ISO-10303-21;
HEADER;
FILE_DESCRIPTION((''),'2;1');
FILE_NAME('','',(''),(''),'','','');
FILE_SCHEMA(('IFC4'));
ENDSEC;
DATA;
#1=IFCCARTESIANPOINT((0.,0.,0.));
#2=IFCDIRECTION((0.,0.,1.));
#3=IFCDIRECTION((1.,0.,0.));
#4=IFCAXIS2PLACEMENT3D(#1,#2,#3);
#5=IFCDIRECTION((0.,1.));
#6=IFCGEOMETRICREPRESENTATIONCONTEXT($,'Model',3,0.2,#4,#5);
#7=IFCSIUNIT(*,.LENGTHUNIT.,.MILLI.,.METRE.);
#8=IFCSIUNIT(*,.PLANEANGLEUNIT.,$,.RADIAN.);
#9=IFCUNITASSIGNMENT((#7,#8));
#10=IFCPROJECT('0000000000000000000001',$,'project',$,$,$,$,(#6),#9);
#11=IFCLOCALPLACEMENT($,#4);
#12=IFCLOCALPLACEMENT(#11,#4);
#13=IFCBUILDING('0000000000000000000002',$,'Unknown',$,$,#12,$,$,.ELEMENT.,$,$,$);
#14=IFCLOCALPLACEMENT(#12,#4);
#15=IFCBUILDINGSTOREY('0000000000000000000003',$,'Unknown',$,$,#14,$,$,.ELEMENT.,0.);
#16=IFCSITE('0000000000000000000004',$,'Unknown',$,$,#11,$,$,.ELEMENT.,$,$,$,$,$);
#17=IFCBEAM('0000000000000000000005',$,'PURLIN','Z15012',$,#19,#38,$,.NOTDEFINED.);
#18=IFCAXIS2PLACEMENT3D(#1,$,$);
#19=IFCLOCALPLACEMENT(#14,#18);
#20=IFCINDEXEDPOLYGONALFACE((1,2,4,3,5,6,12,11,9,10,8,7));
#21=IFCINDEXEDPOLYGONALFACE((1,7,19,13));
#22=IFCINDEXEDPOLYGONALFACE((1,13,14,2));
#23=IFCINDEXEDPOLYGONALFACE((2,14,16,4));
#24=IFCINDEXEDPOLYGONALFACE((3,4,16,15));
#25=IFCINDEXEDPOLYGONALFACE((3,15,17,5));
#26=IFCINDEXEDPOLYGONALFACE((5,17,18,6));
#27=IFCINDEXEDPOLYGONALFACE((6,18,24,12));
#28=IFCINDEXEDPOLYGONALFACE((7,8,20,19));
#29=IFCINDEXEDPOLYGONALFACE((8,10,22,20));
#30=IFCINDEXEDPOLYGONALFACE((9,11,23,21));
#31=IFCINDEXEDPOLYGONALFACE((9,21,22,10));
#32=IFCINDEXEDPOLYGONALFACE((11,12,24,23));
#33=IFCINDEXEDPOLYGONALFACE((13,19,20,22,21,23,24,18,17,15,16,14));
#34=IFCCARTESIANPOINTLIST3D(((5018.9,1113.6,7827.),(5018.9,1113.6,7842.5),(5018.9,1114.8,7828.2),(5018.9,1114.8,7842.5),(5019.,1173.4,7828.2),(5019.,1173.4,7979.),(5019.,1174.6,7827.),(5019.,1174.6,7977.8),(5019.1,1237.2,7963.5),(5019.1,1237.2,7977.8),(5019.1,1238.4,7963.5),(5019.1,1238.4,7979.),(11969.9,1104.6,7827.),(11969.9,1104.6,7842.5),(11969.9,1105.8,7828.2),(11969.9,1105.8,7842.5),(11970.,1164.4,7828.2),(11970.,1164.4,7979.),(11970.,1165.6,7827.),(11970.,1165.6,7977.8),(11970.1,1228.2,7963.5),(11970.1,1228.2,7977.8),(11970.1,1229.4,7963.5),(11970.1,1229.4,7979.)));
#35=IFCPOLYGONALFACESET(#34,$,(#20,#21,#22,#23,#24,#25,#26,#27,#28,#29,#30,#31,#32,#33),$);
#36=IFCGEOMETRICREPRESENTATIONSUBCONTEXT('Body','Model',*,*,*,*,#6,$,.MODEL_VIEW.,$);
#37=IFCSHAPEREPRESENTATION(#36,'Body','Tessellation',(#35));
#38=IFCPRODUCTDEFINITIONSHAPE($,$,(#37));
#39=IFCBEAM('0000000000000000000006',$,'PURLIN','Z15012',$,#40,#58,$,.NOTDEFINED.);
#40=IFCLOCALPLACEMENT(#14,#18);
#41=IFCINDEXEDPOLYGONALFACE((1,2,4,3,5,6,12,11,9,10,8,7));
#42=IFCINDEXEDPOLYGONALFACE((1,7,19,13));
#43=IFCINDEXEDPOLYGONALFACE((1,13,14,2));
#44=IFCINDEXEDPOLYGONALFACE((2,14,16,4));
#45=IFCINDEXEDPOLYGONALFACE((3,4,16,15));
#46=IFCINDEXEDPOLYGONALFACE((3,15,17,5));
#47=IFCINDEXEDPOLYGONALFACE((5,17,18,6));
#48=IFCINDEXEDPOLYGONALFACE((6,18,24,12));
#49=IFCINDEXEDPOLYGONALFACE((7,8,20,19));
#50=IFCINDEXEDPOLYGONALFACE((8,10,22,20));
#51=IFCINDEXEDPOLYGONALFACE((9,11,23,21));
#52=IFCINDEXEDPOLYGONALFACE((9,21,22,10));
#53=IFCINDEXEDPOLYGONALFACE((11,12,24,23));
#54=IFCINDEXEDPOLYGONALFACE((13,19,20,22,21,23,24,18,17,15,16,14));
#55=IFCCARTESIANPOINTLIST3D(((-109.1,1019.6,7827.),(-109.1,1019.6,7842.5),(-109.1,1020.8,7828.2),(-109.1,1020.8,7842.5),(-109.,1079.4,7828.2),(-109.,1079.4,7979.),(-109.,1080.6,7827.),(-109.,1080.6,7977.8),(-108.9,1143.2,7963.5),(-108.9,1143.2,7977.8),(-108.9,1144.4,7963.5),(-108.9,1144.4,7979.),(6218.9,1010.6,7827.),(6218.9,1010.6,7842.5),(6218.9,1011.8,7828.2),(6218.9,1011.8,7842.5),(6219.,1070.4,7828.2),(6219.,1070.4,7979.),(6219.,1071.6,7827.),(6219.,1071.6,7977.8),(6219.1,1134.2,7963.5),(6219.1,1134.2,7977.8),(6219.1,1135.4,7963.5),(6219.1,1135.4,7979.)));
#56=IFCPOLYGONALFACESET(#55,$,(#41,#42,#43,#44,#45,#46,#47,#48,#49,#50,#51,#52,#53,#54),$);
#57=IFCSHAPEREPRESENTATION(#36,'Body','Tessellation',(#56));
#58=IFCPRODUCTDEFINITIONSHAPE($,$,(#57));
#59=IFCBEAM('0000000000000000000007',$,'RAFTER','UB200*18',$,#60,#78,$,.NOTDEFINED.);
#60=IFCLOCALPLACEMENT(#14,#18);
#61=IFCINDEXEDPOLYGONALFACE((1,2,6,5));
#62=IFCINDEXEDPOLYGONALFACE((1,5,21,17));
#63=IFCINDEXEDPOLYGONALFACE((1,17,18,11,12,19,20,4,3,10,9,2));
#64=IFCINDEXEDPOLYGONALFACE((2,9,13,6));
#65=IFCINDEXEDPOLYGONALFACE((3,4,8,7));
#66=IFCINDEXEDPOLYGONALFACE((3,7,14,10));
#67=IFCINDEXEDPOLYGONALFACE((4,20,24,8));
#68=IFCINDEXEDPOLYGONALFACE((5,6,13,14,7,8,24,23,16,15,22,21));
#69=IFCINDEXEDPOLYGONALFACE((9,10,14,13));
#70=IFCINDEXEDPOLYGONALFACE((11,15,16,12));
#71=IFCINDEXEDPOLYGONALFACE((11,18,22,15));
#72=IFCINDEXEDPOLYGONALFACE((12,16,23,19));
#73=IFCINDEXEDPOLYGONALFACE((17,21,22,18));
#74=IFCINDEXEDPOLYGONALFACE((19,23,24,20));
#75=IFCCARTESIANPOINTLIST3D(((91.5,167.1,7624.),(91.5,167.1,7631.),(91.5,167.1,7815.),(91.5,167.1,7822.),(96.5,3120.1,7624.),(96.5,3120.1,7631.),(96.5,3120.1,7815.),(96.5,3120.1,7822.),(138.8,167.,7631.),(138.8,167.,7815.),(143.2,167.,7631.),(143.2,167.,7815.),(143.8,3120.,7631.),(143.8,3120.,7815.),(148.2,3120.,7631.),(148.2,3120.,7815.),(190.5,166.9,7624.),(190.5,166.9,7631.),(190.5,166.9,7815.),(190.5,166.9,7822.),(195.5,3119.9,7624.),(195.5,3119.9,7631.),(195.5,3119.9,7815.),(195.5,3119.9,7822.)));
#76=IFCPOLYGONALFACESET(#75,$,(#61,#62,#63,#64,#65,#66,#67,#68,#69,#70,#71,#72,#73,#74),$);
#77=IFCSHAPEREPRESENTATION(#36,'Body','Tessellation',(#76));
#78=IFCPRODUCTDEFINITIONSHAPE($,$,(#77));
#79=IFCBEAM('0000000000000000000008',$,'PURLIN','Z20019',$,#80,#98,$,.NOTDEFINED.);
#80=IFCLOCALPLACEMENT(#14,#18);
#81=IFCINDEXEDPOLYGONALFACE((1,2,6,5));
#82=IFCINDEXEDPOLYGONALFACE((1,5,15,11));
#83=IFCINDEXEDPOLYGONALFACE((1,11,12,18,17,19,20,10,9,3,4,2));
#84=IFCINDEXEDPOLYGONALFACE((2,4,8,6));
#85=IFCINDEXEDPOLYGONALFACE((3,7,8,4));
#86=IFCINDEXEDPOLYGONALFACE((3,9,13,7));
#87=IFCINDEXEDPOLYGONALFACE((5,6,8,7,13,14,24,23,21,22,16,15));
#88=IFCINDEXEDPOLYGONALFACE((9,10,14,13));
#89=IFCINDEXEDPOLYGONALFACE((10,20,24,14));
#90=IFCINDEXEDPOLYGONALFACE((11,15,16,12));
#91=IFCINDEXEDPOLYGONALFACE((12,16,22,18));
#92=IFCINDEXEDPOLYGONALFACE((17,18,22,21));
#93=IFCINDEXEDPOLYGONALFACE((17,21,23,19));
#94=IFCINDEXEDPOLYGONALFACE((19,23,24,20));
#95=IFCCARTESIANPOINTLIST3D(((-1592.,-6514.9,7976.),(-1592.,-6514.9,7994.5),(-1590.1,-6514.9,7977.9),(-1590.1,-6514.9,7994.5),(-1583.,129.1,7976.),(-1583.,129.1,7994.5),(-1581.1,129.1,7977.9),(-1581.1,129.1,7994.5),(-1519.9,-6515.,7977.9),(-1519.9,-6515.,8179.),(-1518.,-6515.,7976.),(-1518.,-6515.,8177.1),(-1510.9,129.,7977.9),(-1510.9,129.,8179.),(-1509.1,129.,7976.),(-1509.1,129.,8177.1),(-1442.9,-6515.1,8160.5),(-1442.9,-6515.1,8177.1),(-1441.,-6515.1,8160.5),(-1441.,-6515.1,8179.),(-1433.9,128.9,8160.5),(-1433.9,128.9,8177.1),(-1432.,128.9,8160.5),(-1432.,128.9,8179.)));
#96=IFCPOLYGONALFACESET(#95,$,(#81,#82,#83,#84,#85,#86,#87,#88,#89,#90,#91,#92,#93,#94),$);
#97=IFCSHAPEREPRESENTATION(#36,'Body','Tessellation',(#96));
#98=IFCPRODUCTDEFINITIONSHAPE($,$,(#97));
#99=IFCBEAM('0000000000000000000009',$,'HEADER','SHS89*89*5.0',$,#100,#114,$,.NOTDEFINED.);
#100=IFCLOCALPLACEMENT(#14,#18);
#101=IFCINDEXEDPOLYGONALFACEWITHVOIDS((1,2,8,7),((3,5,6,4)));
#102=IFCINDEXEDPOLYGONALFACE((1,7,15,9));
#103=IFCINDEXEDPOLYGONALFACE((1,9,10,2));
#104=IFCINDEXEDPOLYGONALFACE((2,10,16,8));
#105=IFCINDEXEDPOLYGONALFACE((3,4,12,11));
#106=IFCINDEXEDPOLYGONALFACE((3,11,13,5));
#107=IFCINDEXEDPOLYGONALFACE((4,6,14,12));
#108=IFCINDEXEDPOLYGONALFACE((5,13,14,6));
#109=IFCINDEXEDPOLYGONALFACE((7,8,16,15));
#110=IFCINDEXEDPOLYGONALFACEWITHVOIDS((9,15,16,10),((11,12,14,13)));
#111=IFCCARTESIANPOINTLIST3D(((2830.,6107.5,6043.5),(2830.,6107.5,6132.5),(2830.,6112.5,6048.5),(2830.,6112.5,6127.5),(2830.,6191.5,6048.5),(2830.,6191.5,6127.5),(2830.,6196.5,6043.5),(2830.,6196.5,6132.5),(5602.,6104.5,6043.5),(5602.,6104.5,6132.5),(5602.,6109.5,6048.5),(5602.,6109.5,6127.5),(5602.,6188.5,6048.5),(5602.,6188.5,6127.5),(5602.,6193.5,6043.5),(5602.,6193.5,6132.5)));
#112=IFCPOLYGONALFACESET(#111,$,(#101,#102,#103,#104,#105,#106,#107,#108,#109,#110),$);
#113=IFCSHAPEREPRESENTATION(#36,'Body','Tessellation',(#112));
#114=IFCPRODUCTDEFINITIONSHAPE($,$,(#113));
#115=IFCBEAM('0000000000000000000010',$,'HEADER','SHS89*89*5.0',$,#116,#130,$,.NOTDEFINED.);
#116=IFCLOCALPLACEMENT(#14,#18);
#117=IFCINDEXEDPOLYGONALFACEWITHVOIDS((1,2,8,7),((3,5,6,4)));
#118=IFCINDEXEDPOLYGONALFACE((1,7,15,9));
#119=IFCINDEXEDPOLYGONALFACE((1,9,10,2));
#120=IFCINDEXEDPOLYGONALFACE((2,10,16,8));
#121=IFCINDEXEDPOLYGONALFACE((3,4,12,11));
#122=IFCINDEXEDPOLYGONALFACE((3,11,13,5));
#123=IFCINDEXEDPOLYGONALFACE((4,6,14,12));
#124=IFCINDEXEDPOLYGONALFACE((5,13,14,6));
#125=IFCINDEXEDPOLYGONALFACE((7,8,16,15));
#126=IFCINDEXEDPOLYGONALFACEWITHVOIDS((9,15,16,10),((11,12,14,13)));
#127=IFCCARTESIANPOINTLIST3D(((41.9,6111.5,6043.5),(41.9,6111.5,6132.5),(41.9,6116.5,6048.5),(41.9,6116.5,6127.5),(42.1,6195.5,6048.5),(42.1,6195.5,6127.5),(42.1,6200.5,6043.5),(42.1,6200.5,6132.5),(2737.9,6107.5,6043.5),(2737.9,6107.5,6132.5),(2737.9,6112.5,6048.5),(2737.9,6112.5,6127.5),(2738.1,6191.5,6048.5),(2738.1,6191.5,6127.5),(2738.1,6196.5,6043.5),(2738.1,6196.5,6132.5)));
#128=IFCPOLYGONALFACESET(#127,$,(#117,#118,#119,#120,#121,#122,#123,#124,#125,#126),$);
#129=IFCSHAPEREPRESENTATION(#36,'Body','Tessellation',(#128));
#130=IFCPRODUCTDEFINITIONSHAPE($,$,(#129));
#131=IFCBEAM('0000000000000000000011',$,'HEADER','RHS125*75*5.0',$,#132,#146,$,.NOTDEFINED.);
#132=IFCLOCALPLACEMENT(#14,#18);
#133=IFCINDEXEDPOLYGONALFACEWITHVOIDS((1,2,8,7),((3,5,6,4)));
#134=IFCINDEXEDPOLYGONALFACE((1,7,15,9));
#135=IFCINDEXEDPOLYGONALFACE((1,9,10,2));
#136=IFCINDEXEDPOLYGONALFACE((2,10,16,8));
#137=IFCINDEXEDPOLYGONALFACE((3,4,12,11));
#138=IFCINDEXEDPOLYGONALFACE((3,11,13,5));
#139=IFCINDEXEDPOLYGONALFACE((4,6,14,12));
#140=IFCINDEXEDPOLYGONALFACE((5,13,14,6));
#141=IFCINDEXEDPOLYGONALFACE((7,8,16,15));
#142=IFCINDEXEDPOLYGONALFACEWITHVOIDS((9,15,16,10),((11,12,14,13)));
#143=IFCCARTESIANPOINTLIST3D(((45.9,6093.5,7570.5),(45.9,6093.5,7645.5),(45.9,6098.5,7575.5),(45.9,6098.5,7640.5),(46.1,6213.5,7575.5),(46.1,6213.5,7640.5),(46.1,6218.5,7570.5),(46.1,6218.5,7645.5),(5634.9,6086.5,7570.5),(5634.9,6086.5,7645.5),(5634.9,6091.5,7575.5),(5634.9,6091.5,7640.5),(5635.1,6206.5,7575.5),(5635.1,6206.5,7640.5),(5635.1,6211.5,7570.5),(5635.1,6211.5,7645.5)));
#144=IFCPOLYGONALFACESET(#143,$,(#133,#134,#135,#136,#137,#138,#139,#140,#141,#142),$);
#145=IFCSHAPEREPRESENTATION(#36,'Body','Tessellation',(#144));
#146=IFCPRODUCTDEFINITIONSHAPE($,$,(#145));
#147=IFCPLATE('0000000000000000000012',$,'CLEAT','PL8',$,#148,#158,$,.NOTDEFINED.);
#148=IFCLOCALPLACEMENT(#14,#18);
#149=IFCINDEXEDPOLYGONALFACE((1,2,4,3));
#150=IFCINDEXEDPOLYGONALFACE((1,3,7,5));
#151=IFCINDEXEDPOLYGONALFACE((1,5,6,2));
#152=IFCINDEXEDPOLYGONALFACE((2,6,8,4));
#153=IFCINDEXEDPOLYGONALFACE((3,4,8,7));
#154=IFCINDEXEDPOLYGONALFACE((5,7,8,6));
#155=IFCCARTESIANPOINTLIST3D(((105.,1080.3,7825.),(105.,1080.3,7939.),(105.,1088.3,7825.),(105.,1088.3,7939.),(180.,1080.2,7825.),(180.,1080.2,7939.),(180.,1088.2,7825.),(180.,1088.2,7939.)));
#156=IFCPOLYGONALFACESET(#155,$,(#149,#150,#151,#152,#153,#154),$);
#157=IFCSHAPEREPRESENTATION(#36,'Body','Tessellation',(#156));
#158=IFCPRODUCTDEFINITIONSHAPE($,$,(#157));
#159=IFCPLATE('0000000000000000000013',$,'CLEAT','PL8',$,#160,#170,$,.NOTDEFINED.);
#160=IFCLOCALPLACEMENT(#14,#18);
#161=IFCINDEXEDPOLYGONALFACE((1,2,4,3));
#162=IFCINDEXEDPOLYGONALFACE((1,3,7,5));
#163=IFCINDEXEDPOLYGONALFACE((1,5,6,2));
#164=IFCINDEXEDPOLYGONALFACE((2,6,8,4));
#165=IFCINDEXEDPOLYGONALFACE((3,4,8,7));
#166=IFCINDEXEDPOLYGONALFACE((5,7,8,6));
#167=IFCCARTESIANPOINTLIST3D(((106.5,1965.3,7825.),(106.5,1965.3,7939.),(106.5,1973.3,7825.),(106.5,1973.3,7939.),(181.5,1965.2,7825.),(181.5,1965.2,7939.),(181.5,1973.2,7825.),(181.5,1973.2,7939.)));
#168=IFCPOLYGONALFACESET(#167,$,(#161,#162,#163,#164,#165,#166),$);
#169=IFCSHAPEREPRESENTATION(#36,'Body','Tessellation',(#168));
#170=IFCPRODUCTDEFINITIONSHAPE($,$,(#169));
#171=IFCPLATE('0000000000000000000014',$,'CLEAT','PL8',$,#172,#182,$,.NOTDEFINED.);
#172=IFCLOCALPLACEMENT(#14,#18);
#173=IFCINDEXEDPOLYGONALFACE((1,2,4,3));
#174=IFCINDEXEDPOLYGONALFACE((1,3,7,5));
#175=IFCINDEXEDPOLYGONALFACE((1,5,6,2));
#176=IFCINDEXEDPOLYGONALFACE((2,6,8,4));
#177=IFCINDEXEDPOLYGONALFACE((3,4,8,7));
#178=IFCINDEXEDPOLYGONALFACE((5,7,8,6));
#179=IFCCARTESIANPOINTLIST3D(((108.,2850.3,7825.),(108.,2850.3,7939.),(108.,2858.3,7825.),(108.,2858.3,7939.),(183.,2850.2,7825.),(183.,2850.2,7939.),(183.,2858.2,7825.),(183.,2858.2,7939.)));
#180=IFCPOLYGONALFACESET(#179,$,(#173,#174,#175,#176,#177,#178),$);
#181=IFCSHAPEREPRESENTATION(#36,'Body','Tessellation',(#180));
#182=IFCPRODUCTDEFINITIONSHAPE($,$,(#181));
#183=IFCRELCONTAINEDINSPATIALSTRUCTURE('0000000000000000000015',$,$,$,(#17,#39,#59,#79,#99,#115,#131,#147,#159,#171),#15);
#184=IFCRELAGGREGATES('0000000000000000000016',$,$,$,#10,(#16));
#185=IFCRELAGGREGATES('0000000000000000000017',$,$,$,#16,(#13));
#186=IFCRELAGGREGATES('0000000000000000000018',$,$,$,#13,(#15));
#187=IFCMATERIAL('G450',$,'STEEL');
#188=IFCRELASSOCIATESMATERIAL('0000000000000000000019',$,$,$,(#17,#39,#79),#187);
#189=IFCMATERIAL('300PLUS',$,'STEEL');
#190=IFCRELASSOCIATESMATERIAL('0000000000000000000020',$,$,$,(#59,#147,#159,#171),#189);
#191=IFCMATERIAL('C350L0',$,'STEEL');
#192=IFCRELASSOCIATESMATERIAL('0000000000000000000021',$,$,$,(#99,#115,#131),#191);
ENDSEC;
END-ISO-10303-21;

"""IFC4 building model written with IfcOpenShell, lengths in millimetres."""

from ifc_helpers import new_model, si_unit, direction, frame, origin_with_axes, place, context, subcontext, project, spatial, line, indexed_curve, outline, extrude, material, element, save


model = new_model("IFC4")

# Units and contexts
model_context = context("Model", 3, precision=0.2, world=origin_with_axes(), true_north=direction((0.0, 1.0)))
body_context = subcontext(model_context, "Body", "Model", "MODEL_VIEW")
ifc_project = project(units=[si_unit("LENGTHUNIT", "METRE", prefix="MILLI"), si_unit("PLANEANGLEUNIT", "RADIAN")], contexts=[model_context])

# Site, building, storey
site_placement = place(None, origin_with_axes())
site = spatial("IfcSite", under=ifc_project, at=site_placement, Name="Unknown", CompositionType="ELEMENT")
building_placement = place(site_placement, origin_with_axes())
building = spatial("IfcBuilding", under=site, at=building_placement, Name="Unknown", CompositionType="ELEMENT")
storey_placement = place(building_placement, origin_with_axes())
storey = spatial("IfcBuildingStorey", under=building, at=storey_placement, Name="Unknown", CompositionType="ELEMENT", Elevation=0.0)

# Shared definitions
ifc_material_1 = material(Name="C350L0", Category="STEEL")

# Beams
ifc_material_2 = material(Name="G450", Category="STEEL")
beam_1_placement = place(storey_placement, frame((5019.0, 1174.0, 7903.0), z_axis=(-0.001295, -0.999999, 0.0), x_axis=(0.999999, -0.001295, 0.0)))
element("IfcBeam", 1, at=beam_1_placement, inside=storey, material=ifc_material_2, Name="PURLIN", Description="Z15012", PredefinedType="NOTDEFINED", context=body_context, shape_type="SolidModel", body=[
    extrude(outline(indexed_curve([(60.4, -76.0), (60.4, -60.5), (59.2, -60.5), (59.2, -74.8), (0.6, -74.8), (0.6, 76.0), (-64.4, 76.0), (-64.4, 60.5), (-63.2, 60.5), (-63.2, 74.8), (-0.6, 74.8), (-0.6, -76.0)], segments=[line(1, 2, 3, 4, 5, 6, 7, 8, 9, 10, 11, 12, 1)])), frame((0.0, 0.0, 0.0), z_axis=(-1.0, 0.0, 0.0), x_axis=(0.0, 0.0, 1.0)), (0.0, 0.0, -1.0), 6951.0),
])
beam_2_placement = place(storey_placement, frame((-109.0, 1080.0, 7903.0), z_axis=(-0.001422, -0.999999, 0.0), x_axis=(0.999999, -0.001422, 0.0)))
element("IfcBeam", 2, at=beam_2_placement, inside=storey, material=ifc_material_2, Name="PURLIN", Description="Z15012", PredefinedType="NOTDEFINED", context=body_context, shape_type="SolidModel", body=[
    extrude(outline(indexed_curve([(60.4, -76.0), (60.4, -60.5), (59.2, -60.5), (59.2, -74.8), (0.6, -74.8), (0.6, 76.0), (-64.4, 76.0), (-64.4, 60.5), (-63.2, 60.5), (-63.2, 74.8), (-0.6, 74.8), (-0.6, -76.0)], segments=[line(1, 2, 3, 4, 5, 6, 7, 8, 9, 10, 11, 12, 1)])), frame((0.0, 0.0, 0.0), z_axis=(-1.0, 0.0, 0.0), x_axis=(0.0, 0.0, 1.0)), (0.0, 0.0, -1.0), 6328.0),
])
ifc_material_3 = material(Name="300PLUS", Category="STEEL")
beam_3_placement = place(storey_placement, frame((141.0, 167.0, 7723.0), z_axis=(0.999999, -0.001693, 0.0), x_axis=(0.001693, 0.999999, 0.0)))
element("IfcBeam", 3, at=beam_3_placement, inside=storey, material=ifc_material_3, Name="RAFTER", Description="UB200*18", PredefinedType="NOTDEFINED", context=body_context, shape_type="SolidModel", body=[
    extrude(outline(indexed_curve([(-49.5, -99.0), (49.5, -99.0), (49.5, -92.0), (2.2, -92.0), (2.2, 92.0), (49.5, 92.0), (49.5, 99.0), (-49.5, 99.0), (-49.5, 92.0), (-2.2, 92.0), (-2.2, -92.0), (-49.5, -92.0)], segments=[line(1, 2, 3, 4, 5, 6, 7, 8, 9, 10, 11, 12, 1)])), frame((0.0, 0.0, 0.0), z_axis=(-1.0, 0.0, 0.0), x_axis=(0.0, 0.0, 1.0)), (0.0, 0.0, -1.0), 2953.0),
])
beam_4_placement = place(storey_placement, frame((-1510.0, 129.0, 8077.5), z_axis=(-0.999999, 0.001355, 0.0), x_axis=(-0.001355, -0.999999, 0.0)))
element("IfcBeam", 4, at=beam_4_placement, inside=storey, material=ifc_material_2, Name="PURLIN", Description="Z20019", PredefinedType="NOTDEFINED", context=body_context, shape_type="SolidModel", body=[
    extrude(outline(indexed_curve([(73.0, -101.5), (73.0, -83.0), (71.2, -83.0), (71.2, -99.6), (0.9, -99.6), (0.9, 101.5), (-78.0, 101.5), (-78.0, 83.0), (-76.2, 83.0), (-76.2, 99.6), (-0.9, 99.6), (-0.9, -101.5)], segments=[line(1, 2, 3, 4, 5, 6, 7, 8, 9, 10, 11, 12, 1)])), frame((0.0, 0.0, 0.0), z_axis=(-1.0, 0.0, 0.0), x_axis=(0.0, 0.0, 1.0)), (0.0, 0.0, -1.0), 6644.0),
])
beam_5_placement = place(storey_placement, frame((2830.0, 6152.0, 6088.0), z_axis=(0.0, 0.0, 1.0), x_axis=(0.999999, -0.001082, 0.0)))
element("IfcBeam", 5, at=beam_5_placement, inside=storey, material=ifc_material_1, Name="HEADER", Description="SHS89*89*5.0", PredefinedType="NOTDEFINED", context=body_context, shape_type="SolidModel", body=[
    extrude(outline(indexed_curve([(-44.5, -44.5), (44.5, -44.5), (44.5, 44.5), (-44.5, 44.5)], segments=[line(1, 2, 3, 4, 1)]), holes=[indexed_curve([(-39.5, -39.5), (-39.5, 39.5), (39.5, 39.5), (39.5, -39.5)], segments=[line(1, 2, 3, 4, 1)])]), frame((0.0, 0.0, 0.0), z_axis=(-1.0, 0.0, 0.0), x_axis=(0.0, 0.0, 1.0)), (0.0, 0.0, -1.0), 2772.0),
])
beam_6_placement = place(storey_placement, frame((42.0, 6156.0, 6088.0), z_axis=(0.0, 0.0, 1.0), x_axis=(0.999999, -0.001484, 0.0)))
element("IfcBeam", 6, at=beam_6_placement, inside=storey, material=ifc_material_1, Name="HEADER", Description="SHS89*89*5.0", PredefinedType="NOTDEFINED", context=body_context, shape_type="SolidModel", body=[
    extrude(outline(indexed_curve([(-44.5, -44.5), (44.5, -44.5), (44.5, 44.5), (-44.5, 44.5)], segments=[line(1, 2, 3, 4, 1)]), holes=[indexed_curve([(-39.5, -39.5), (-39.5, 39.5), (39.5, 39.5), (39.5, -39.5)], segments=[line(1, 2, 3, 4, 1)])]), frame((0.0, 0.0, 0.0), z_axis=(-1.0, 0.0, 0.0), x_axis=(0.0, 0.0, 1.0)), (0.0, 0.0, -1.0), 2696.0),
])
beam_7_placement = place(storey_placement, frame((46.0, 6156.0, 7608.0), z_axis=(0.0, 0.0, 1.0), x_axis=(0.999999, -0.001252, 0.0)))
element("IfcBeam", 7, at=beam_7_placement, inside=storey, material=ifc_material_1, Name="HEADER", Description="RHS125*75*5.0", PredefinedType="NOTDEFINED", context=body_context, shape_type="SolidModel", body=[
    extrude(outline(indexed_curve([(-37.5, -62.5), (37.5, -62.5), (37.5, 62.5), (-37.5, 62.5)], segments=[line(1, 2, 3, 4, 1)]), holes=[indexed_curve([(-32.5, -57.5), (-32.5, 57.5), (32.5, 57.5), (32.5, -57.5)], segments=[line(1, 2, 3, 4, 1)])]), frame((0.0, 0.0, 0.0), z_axis=(-1.0, 0.0, 0.0), x_axis=(0.0, 0.0, 1.0)), (0.0, 0.0, -1.0), 5589.0),
])

# Plates
for number, where, z_axis, x_axis, name in (
    (8, (105.0, 1084.3, 7939.0), (0.001333, 0.999999, 0.0), (0.999999, -0.001333, 0.0), "CLEAT"),
    (9, (106.5, 1969.3, 7939.0), (0.001333, 0.999999, 0.0), (0.999999, -0.001333, 0.0), "CLEAT"),
    (10, (108.0, 2854.3, 7939.0), (0.001333, 0.999999, 0.0), (0.999999, -0.001333, 0.0), "CLEAT"),
):
    element("IfcPlate", number, at=place(storey_placement, frame(where, z_axis=z_axis, x_axis=x_axis)), inside=storey, material=ifc_material_3, Name=name, Description="PL8", PredefinedType="NOTDEFINED", context=body_context, shape_type="SolidModel", body=[
        extrude(outline(indexed_curve([(0.0, 0.0), (75.0, 0.0), (75.0, 114.0), (0.0, 114.0)], segments=[line(1, 2, 3, 4, 1)])), frame((0.0, 0.0, 4.0), z_axis=(0.0, 0.0, 1.0), x_axis=(1.0, 0.0, 0.0)), (0.0, 0.0, -1.0), 8.0),
    ])

save(model, "model.ifc")
